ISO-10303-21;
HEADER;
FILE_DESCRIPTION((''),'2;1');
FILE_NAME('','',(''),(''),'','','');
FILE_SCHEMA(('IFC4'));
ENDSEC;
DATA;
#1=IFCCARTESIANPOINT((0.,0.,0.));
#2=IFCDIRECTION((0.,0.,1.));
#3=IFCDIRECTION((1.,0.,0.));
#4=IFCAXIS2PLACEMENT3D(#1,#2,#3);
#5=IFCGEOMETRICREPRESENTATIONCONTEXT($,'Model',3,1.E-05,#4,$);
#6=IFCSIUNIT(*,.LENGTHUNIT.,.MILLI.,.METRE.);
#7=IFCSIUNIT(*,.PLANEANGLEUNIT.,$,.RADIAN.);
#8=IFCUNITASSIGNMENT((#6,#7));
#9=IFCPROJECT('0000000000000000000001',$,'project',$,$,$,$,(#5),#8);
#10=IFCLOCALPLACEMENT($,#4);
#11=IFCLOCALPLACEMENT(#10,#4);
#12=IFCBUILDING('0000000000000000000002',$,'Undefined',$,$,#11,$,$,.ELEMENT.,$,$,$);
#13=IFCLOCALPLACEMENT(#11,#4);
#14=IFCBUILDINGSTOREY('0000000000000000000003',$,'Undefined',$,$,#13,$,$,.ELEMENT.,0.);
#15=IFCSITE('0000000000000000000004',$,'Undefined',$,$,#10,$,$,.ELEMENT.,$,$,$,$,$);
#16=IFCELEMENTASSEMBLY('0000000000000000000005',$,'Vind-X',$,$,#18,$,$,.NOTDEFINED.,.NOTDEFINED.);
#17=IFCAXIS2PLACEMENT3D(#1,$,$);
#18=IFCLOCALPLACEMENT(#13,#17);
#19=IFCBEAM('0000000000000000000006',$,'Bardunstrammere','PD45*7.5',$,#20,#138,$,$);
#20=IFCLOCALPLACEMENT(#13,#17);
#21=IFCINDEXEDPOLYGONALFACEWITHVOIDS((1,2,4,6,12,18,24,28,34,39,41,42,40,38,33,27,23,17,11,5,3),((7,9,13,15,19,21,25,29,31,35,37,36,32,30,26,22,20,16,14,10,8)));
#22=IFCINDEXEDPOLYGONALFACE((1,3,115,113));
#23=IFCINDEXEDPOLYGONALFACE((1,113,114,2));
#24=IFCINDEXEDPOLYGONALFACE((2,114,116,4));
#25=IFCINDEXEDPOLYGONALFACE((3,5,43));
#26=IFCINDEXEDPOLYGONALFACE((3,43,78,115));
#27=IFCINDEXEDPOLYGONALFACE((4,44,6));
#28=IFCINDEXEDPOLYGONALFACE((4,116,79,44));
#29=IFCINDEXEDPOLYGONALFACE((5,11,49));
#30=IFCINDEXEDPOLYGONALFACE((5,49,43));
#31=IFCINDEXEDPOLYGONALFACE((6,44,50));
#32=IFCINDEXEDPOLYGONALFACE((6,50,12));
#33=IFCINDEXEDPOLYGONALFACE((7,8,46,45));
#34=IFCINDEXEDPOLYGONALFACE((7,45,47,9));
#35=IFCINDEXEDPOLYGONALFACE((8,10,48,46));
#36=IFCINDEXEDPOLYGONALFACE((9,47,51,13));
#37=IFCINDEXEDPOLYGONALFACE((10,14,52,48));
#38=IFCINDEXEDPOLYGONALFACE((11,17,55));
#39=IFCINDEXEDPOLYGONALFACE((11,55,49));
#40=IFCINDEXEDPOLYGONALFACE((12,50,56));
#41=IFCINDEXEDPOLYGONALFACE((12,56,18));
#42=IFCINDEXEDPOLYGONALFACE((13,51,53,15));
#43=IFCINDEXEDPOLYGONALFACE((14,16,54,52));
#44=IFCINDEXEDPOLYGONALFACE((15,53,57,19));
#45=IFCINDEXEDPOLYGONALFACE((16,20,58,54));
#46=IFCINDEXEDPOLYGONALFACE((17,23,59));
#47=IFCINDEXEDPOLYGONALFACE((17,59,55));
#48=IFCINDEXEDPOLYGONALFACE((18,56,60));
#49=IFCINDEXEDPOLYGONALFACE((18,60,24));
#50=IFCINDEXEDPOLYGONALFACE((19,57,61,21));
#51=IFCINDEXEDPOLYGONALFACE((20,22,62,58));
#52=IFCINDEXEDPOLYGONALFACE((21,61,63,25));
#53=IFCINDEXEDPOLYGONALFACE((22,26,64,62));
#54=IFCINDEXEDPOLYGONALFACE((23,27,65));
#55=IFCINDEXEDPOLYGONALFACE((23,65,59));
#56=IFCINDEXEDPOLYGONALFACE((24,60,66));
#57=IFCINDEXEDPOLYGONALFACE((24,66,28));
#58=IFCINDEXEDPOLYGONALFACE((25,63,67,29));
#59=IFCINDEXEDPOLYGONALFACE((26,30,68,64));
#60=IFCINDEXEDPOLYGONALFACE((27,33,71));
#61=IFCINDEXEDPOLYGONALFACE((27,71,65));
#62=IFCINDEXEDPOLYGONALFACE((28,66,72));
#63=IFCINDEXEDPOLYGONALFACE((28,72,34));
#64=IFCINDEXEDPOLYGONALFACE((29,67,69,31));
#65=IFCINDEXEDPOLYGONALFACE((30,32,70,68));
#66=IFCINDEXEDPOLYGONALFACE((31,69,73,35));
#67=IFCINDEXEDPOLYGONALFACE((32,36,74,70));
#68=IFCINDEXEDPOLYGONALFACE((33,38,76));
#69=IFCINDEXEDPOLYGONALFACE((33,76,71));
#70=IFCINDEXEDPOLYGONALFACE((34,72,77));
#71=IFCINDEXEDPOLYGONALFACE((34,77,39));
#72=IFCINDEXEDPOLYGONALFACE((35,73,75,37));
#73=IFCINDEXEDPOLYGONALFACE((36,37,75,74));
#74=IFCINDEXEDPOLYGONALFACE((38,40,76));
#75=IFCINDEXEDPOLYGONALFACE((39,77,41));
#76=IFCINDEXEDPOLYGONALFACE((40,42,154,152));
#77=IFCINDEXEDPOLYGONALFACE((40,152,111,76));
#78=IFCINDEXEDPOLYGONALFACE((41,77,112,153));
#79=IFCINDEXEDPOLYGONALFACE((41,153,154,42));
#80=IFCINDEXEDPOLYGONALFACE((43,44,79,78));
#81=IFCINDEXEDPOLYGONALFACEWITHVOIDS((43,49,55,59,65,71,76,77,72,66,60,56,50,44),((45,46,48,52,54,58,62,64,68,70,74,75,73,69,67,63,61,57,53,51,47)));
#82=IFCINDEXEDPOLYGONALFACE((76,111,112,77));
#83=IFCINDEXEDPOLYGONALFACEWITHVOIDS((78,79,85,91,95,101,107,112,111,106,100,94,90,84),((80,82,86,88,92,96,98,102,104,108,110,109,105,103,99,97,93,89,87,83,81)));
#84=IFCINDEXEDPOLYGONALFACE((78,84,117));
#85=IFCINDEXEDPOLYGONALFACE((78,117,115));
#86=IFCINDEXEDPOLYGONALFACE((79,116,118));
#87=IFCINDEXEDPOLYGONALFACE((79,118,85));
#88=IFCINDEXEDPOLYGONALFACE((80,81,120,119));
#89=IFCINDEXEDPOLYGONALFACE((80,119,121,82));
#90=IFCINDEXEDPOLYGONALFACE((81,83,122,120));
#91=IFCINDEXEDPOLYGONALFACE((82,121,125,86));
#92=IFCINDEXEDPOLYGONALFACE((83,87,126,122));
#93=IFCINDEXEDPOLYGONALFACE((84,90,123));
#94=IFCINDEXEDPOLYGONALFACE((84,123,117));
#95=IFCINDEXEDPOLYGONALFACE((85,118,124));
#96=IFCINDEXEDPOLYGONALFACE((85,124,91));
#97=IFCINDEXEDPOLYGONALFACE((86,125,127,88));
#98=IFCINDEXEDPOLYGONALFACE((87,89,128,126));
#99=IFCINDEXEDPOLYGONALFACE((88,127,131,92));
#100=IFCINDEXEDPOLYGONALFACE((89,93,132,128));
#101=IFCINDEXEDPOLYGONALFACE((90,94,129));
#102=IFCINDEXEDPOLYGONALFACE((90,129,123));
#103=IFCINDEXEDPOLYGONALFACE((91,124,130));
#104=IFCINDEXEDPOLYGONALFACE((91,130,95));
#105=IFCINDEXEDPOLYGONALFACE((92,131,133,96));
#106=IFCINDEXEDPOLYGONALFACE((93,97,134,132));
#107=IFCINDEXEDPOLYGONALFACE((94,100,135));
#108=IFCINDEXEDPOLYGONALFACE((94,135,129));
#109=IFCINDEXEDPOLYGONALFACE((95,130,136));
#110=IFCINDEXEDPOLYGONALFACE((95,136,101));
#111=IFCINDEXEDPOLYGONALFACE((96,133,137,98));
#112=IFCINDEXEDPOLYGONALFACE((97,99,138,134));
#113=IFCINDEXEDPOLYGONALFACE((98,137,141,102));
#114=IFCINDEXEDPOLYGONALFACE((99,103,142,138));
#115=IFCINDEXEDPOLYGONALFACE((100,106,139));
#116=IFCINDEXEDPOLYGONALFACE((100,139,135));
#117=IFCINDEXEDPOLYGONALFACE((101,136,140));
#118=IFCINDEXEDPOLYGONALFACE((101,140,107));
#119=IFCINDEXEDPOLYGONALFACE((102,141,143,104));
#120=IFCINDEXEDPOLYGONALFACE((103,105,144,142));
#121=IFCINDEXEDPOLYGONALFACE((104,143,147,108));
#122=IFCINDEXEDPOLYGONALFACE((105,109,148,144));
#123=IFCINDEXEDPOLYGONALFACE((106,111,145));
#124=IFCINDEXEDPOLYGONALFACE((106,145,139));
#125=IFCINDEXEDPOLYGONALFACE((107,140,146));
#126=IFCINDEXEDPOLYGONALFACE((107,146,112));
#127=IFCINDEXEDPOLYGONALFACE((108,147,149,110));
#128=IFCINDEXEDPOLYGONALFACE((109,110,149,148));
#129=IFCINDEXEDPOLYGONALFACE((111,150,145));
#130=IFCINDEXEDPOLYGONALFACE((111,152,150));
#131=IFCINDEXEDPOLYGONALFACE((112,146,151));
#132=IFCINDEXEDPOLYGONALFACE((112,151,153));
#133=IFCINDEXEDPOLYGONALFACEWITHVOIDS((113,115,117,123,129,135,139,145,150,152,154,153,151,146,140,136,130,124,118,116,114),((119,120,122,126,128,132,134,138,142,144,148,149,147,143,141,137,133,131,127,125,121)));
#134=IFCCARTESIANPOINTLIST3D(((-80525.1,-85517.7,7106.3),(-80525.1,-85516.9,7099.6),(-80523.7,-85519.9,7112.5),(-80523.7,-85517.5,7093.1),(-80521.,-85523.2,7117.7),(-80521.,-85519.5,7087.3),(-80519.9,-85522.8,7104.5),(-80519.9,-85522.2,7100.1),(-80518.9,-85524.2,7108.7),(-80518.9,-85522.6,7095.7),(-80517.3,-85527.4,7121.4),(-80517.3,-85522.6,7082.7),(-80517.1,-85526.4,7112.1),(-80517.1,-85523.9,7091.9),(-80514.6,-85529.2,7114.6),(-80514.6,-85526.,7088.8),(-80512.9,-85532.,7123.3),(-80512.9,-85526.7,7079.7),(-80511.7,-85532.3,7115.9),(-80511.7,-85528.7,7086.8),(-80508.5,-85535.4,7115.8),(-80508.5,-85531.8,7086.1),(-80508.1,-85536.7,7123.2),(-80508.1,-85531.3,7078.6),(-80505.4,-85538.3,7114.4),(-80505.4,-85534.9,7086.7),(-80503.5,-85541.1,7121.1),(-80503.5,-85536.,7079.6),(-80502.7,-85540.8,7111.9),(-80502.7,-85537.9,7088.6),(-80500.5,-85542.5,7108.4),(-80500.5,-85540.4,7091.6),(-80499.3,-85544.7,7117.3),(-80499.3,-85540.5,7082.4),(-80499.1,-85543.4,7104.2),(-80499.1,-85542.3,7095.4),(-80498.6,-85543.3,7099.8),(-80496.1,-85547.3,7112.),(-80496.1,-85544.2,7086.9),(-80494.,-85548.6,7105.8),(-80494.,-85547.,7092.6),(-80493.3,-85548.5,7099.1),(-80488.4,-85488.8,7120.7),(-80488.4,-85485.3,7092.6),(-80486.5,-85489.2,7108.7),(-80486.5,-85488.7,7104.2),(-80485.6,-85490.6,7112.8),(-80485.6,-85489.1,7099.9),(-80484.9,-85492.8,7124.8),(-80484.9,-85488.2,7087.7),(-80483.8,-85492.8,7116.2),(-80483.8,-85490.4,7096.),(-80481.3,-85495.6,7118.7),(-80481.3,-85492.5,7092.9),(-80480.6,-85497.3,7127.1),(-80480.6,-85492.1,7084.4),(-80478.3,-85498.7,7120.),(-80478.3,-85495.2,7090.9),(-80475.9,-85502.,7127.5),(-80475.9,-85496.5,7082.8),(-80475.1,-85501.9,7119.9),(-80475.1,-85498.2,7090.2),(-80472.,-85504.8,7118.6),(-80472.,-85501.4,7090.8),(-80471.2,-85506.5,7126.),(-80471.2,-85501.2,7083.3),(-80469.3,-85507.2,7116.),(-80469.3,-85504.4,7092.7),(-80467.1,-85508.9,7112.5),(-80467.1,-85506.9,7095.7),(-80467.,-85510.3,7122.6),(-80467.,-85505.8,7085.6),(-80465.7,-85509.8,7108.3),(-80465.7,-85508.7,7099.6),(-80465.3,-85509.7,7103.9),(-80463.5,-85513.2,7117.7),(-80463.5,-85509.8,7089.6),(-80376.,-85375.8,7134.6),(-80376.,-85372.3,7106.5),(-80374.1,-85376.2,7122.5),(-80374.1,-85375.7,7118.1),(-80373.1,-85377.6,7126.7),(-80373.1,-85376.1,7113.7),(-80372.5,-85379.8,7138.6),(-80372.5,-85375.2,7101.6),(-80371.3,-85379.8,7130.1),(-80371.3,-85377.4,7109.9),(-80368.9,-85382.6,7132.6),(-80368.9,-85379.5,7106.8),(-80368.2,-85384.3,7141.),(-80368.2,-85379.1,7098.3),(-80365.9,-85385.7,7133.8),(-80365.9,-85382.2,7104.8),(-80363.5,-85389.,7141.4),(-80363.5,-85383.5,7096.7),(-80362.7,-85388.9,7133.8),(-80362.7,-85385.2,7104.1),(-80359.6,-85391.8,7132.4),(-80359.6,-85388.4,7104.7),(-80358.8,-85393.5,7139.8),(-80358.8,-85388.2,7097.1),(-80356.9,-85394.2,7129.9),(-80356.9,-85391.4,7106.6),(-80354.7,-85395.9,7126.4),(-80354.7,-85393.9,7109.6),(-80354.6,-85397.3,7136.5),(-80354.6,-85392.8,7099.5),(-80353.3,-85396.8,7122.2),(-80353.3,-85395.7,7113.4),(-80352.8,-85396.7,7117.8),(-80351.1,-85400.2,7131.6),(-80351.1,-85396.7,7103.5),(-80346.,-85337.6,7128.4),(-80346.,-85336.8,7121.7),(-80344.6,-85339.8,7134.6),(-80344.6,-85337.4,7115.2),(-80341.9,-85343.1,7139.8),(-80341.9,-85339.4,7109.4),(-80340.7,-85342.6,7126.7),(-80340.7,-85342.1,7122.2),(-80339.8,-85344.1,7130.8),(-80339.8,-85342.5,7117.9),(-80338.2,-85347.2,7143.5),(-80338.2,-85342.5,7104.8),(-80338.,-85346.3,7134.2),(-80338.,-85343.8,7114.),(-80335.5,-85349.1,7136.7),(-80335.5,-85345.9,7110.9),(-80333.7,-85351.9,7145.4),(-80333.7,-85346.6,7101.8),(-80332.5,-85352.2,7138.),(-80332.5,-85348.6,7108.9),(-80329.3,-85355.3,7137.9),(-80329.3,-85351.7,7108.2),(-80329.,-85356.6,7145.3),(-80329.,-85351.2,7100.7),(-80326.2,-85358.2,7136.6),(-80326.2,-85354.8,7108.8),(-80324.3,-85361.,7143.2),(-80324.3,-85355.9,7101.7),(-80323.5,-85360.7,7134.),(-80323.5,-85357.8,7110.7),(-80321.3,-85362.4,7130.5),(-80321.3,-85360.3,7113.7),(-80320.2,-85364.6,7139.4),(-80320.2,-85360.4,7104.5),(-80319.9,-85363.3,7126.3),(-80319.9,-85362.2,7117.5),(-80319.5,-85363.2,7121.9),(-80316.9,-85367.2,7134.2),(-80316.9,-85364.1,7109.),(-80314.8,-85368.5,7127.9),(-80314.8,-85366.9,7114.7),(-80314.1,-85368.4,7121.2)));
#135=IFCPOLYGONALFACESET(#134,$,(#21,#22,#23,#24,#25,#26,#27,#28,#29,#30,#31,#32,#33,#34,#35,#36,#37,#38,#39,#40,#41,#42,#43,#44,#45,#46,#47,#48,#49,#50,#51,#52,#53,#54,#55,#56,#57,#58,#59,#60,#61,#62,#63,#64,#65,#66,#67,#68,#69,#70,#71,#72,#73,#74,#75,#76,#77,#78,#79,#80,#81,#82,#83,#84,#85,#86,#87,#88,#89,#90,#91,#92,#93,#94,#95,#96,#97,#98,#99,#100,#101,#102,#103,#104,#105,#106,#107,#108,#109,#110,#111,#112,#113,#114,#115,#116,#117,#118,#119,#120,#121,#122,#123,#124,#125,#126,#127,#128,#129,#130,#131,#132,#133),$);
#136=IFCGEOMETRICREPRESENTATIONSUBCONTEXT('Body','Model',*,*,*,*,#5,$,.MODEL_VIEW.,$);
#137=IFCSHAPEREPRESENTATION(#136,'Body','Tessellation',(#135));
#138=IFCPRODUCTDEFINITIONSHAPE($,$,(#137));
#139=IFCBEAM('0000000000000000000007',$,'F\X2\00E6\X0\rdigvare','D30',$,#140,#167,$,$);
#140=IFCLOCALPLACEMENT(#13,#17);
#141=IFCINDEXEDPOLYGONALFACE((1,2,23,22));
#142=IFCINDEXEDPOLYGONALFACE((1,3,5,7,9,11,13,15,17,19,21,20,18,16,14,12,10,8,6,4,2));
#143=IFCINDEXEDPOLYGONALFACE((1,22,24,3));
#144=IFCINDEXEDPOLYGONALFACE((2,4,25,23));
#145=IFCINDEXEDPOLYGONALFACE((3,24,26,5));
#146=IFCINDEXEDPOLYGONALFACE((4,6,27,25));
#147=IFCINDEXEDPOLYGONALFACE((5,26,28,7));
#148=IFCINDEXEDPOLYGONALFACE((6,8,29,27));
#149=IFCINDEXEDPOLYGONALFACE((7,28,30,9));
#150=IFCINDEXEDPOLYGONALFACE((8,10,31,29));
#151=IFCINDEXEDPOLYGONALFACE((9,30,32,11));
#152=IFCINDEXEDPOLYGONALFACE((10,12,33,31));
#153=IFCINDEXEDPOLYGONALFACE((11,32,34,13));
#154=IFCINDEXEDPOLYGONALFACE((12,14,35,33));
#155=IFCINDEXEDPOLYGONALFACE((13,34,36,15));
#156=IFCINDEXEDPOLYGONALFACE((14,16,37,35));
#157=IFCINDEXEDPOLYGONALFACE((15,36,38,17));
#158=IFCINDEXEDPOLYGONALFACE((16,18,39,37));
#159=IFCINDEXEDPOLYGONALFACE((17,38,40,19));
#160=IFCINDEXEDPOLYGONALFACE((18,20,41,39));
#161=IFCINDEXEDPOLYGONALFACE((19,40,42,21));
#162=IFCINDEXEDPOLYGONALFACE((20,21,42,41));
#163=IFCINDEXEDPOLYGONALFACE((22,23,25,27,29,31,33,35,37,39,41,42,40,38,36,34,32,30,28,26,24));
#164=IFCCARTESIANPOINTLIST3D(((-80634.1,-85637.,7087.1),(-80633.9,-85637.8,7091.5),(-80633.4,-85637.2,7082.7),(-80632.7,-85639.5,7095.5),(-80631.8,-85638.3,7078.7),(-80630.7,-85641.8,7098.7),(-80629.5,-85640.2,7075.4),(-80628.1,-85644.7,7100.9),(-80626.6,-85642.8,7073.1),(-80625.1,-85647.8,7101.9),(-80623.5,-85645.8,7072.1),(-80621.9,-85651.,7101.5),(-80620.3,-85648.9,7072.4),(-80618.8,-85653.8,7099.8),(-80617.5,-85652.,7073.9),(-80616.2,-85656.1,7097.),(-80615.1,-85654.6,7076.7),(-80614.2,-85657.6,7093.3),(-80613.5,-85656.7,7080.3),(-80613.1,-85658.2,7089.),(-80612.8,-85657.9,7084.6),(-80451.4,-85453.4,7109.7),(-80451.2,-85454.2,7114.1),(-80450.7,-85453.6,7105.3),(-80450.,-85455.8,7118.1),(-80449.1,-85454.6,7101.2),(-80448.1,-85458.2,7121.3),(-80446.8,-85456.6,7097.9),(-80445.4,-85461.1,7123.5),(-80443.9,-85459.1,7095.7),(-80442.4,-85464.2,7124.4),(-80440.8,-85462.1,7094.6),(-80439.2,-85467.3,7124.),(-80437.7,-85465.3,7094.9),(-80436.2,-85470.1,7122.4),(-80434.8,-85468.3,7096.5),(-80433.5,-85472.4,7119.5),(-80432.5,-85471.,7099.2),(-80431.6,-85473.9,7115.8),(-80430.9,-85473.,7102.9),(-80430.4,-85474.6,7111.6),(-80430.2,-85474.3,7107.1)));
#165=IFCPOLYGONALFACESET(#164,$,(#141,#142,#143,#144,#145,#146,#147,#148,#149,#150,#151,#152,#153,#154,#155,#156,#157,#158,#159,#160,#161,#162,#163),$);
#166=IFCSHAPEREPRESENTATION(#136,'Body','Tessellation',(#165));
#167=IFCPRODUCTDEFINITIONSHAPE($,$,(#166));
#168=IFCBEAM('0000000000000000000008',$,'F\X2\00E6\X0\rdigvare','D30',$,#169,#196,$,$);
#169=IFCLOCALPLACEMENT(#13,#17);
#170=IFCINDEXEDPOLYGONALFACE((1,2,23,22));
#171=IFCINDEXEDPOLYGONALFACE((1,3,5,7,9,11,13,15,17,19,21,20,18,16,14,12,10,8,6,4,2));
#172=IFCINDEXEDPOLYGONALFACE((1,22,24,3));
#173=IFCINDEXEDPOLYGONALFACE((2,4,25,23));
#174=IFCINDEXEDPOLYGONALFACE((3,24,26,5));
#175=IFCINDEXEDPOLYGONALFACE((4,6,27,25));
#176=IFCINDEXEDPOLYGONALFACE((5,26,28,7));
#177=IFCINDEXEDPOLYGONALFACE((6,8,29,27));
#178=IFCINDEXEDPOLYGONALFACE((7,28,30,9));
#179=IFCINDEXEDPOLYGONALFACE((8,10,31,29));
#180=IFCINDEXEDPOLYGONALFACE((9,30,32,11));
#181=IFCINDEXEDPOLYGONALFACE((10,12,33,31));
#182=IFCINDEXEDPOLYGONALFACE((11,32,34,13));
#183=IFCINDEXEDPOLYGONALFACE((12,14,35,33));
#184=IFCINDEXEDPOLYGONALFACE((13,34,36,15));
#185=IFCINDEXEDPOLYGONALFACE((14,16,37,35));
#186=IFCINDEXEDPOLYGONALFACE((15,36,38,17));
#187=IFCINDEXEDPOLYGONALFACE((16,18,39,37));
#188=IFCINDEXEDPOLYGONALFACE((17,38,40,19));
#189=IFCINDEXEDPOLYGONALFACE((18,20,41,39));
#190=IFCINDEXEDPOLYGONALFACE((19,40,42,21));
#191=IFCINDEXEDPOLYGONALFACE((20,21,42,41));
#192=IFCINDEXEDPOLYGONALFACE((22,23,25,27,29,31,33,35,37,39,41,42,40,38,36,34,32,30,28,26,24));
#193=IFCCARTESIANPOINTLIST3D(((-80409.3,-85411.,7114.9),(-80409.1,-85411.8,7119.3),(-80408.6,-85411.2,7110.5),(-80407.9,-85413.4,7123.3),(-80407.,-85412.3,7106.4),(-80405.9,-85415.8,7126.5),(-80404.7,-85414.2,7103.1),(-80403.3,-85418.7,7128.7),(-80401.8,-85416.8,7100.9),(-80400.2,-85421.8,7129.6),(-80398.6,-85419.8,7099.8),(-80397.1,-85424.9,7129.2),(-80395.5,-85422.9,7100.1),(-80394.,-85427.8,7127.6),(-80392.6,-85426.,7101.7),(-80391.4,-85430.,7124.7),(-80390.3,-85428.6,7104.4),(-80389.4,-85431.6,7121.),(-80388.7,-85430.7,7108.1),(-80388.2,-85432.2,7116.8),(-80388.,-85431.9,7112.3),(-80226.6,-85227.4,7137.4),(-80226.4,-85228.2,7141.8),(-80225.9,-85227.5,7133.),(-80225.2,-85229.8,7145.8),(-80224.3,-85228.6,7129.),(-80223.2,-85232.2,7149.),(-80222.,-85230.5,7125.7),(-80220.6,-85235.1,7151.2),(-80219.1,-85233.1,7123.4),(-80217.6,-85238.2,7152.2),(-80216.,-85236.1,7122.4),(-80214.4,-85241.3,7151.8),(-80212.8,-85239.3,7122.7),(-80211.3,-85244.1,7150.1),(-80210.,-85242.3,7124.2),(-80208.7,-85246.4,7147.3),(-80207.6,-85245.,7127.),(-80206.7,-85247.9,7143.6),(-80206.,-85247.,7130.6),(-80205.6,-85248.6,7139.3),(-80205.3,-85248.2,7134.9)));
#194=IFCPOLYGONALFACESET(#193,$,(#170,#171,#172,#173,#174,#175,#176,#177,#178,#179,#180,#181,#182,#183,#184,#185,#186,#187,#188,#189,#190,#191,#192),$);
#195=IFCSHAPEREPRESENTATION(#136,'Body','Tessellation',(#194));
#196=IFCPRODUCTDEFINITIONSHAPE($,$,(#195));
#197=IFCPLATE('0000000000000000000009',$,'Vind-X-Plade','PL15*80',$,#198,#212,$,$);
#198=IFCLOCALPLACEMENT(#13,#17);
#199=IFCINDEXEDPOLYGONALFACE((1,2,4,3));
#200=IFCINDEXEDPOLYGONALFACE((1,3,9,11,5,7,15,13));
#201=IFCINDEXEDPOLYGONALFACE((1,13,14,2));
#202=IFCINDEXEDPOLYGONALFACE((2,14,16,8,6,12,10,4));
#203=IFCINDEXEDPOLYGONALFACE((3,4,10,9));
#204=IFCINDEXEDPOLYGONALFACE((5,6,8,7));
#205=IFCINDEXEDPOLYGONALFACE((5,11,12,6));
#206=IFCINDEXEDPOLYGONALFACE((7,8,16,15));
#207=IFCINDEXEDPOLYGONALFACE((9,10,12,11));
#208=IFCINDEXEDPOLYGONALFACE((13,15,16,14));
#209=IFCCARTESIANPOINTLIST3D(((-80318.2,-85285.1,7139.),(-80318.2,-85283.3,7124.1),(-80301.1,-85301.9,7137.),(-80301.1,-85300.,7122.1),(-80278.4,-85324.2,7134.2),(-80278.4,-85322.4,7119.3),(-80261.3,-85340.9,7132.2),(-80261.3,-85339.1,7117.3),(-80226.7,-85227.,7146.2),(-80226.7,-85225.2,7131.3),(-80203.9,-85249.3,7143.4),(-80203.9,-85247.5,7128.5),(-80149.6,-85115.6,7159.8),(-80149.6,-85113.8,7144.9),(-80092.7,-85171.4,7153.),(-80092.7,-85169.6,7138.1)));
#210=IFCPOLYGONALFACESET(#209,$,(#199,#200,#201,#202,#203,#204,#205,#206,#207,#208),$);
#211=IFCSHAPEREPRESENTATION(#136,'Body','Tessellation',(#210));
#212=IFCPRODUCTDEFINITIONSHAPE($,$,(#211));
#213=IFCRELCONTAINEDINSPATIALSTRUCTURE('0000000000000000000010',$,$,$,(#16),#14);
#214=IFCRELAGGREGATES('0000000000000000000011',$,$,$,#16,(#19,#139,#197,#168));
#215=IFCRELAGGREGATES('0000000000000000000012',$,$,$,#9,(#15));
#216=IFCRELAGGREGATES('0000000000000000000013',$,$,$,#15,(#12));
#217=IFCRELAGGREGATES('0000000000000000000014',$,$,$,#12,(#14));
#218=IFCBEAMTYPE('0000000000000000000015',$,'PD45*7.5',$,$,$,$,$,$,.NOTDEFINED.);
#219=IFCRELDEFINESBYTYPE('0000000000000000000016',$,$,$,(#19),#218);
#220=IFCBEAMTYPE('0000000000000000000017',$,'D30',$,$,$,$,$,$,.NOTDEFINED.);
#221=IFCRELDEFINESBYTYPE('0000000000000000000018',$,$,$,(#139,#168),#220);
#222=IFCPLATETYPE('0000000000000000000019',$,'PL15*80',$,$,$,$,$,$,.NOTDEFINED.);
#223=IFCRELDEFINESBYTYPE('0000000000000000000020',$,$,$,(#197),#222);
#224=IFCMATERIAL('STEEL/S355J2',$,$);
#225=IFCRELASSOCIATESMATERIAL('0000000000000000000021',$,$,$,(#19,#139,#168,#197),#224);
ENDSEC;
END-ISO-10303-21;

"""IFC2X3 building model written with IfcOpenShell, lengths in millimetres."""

from ifc_helpers import new_model, si_unit, frame, origin_with_axes, origin_2d_with_axis, place, context, subcontext, project, spatial, polyline, rectangle, circle, hollow_circle, outline, extrude, boolean, material, type_object, element, aggregate, save


model = new_model("IFC2X3")

# Units and contexts
model_context = context("Model", 3, precision=1e-05, world=origin_with_axes())
body_context = subcontext(model_context, "Body", "Model", "MODEL_VIEW")
ifc_project = project(units=[si_unit("LENGTHUNIT", "METRE", prefix="MILLI"), si_unit("PLANEANGLEUNIT", "RADIAN")], contexts=[model_context])

# Site, building, storey
site_placement = place(None, origin_with_axes())
site = spatial("IfcSite", under=ifc_project, at=site_placement, Name="Undefined", CompositionType="ELEMENT")
building_placement = place(site_placement, origin_with_axes())
building = spatial("IfcBuilding", under=site, at=building_placement, Name="Undefined", CompositionType="ELEMENT")
storey_placement = place(building_placement, origin_with_axes())
storey = spatial("IfcBuildingStorey", under=building, at=storey_placement, Name="Undefined", CompositionType="ELEMENT", Elevation=0.0)

# Element assembly, beams
assembly_1_placement = place(storey_placement, origin_with_axes())
assembly_1 = element("IfcElementAssembly", 1, at=assembly_1_placement, inside=storey, Name="Vind-X", AssemblyPlace="NOTDEFINED", PredefinedType="NOTDEFINED")
ifc_material_1 = material(Name="STEEL/S355J2")
beam_type_1 = type_object("IfcBeamType", Name="PD45*7.5", PredefinedType="NOTDEFINED")
beam_1_placement = place(assembly_1_placement, frame((-80330.1, -85352.7, 7123.2), z_axis=(0.0, 0.121869, -0.992546), x_axis=(-0.702593, -0.706288, -0.086721)))
beam_1 = element("IfcBeam", 2, at=beam_1_placement, type_object=beam_type_1, material=ifc_material_1, Name="Bardunstrammere", Description="PD45*7.5", context=body_context, shape_type="CSG", body=[
    boolean("DIFFERENCE", extrude(hollow_circle(Radius=22.5, WallThickness=7.5, at=origin_2d_with_axis()), frame((255.0, 0.0, 0.0), z_axis=(-1.0, 0.0, 0.0), x_axis=(0.0, -1.0, 0.0)), (0.0, 0.0, 1.0), 255.0), extrude(rectangle(XDim=35.0, YDim=90.0, at=origin_2d_with_axis()), frame((207.5, 0.0, 0.0), z_axis=(-1.0, 0.0, 0.0), x_axis=(0.0, -1.0, 0.0)), (0.0, 0.0, 1.0), 160.0)),
])
beam_type_2 = type_object("IfcBeamType", Name="D30", PredefinedType="NOTDEFINED")
beam_2_placement = place(assembly_1_placement, frame((-80440.8, -85464.0, 7109.5), z_axis=(-0.711591, 0.697357, 0.085625), x_axis=(-0.702594, -0.706287, -0.086721)))
beam_2 = element("IfcBeam", 3, at=beam_2_placement, type_object=beam_type_2, material=ifc_material_1, Name="Færdigvare", Description="D30", context=body_context, shape_type="SweptSolid", body=[
    extrude(circle(Radius=15.0, at=origin_2d_with_axis()), frame((260.0, 0.0, 0.0), z_axis=(-1.0, 0.0, 0.0), x_axis=(0.0, -1.0, 0.0)), (0.0, 0.0, 1.0), 260.0),
])
beam_3_placement = place(assembly_1_placement, frame((-80216.0, -85237.9, 7137.3), z_axis=(-0.711592, 0.697356, 0.085625), x_axis=(-0.702593, -0.706288, -0.086721)))
beam_3 = element("IfcBeam", 4, at=beam_3_placement, type_object=beam_type_2, material=ifc_material_1, Name="Færdigvare", Description="D30", context=body_context, shape_type="SweptSolid", body=[
    extrude(circle(Radius=15.0, at=origin_2d_with_axis()), frame((260.0, 0.0, 0.0), z_axis=(-1.0, 0.0, 0.0), x_axis=(0.0, -1.0, 0.0)), (0.0, 0.0, 1.0), 260.0),
])

# Plate
plate_type_1 = type_object("IfcPlateType", Name="PL15*80", PredefinedType="NOTDEFINED")
plate_1_placement = place(assembly_1_placement, frame((-80092.7, -85170.5, 7145.5), z_axis=(0.0, -0.121869, 0.992546), x_axis=(-0.711592, 0.697356, 0.085625)))
plate_1 = element("IfcPlate", 5, at=plate_1_placement, type_object=plate_type_1, material=ifc_material_1, Name="Vind-X-Plade", Description="PL15*80", context=body_context, shape_type="CSG", body=[
    boolean("DIFFERENCE", extrude(outline(polyline([(0.0, 0.0), (80.0, 0.0), (80.0, 240.0), (0.0, 240.0), (0.0, 0.0)])), frame((0.0, 0.0, -7.5), z_axis=(0.0, 0.0, 1.0), x_axis=(1.0, 0.0, 0.0)), (0.0, 0.0, 1.0), 15.0), extrude(outline(polyline([(0.0, 0.0), (106.0, 0.0), (106.0, 32.0), (0.0, 32.0), (0.0, 0.0)])), frame((56.0, 240.0, 8.5), z_axis=(0.0, 0.0, -1.0), x_axis=(0.0, -1.0, 0.0)), (0.0, 0.0, 1.0), 17.0)),
])

aggregate(assembly_1, [beam_1, beam_2, plate_1, beam_3])

save(model, "model.ifc")
